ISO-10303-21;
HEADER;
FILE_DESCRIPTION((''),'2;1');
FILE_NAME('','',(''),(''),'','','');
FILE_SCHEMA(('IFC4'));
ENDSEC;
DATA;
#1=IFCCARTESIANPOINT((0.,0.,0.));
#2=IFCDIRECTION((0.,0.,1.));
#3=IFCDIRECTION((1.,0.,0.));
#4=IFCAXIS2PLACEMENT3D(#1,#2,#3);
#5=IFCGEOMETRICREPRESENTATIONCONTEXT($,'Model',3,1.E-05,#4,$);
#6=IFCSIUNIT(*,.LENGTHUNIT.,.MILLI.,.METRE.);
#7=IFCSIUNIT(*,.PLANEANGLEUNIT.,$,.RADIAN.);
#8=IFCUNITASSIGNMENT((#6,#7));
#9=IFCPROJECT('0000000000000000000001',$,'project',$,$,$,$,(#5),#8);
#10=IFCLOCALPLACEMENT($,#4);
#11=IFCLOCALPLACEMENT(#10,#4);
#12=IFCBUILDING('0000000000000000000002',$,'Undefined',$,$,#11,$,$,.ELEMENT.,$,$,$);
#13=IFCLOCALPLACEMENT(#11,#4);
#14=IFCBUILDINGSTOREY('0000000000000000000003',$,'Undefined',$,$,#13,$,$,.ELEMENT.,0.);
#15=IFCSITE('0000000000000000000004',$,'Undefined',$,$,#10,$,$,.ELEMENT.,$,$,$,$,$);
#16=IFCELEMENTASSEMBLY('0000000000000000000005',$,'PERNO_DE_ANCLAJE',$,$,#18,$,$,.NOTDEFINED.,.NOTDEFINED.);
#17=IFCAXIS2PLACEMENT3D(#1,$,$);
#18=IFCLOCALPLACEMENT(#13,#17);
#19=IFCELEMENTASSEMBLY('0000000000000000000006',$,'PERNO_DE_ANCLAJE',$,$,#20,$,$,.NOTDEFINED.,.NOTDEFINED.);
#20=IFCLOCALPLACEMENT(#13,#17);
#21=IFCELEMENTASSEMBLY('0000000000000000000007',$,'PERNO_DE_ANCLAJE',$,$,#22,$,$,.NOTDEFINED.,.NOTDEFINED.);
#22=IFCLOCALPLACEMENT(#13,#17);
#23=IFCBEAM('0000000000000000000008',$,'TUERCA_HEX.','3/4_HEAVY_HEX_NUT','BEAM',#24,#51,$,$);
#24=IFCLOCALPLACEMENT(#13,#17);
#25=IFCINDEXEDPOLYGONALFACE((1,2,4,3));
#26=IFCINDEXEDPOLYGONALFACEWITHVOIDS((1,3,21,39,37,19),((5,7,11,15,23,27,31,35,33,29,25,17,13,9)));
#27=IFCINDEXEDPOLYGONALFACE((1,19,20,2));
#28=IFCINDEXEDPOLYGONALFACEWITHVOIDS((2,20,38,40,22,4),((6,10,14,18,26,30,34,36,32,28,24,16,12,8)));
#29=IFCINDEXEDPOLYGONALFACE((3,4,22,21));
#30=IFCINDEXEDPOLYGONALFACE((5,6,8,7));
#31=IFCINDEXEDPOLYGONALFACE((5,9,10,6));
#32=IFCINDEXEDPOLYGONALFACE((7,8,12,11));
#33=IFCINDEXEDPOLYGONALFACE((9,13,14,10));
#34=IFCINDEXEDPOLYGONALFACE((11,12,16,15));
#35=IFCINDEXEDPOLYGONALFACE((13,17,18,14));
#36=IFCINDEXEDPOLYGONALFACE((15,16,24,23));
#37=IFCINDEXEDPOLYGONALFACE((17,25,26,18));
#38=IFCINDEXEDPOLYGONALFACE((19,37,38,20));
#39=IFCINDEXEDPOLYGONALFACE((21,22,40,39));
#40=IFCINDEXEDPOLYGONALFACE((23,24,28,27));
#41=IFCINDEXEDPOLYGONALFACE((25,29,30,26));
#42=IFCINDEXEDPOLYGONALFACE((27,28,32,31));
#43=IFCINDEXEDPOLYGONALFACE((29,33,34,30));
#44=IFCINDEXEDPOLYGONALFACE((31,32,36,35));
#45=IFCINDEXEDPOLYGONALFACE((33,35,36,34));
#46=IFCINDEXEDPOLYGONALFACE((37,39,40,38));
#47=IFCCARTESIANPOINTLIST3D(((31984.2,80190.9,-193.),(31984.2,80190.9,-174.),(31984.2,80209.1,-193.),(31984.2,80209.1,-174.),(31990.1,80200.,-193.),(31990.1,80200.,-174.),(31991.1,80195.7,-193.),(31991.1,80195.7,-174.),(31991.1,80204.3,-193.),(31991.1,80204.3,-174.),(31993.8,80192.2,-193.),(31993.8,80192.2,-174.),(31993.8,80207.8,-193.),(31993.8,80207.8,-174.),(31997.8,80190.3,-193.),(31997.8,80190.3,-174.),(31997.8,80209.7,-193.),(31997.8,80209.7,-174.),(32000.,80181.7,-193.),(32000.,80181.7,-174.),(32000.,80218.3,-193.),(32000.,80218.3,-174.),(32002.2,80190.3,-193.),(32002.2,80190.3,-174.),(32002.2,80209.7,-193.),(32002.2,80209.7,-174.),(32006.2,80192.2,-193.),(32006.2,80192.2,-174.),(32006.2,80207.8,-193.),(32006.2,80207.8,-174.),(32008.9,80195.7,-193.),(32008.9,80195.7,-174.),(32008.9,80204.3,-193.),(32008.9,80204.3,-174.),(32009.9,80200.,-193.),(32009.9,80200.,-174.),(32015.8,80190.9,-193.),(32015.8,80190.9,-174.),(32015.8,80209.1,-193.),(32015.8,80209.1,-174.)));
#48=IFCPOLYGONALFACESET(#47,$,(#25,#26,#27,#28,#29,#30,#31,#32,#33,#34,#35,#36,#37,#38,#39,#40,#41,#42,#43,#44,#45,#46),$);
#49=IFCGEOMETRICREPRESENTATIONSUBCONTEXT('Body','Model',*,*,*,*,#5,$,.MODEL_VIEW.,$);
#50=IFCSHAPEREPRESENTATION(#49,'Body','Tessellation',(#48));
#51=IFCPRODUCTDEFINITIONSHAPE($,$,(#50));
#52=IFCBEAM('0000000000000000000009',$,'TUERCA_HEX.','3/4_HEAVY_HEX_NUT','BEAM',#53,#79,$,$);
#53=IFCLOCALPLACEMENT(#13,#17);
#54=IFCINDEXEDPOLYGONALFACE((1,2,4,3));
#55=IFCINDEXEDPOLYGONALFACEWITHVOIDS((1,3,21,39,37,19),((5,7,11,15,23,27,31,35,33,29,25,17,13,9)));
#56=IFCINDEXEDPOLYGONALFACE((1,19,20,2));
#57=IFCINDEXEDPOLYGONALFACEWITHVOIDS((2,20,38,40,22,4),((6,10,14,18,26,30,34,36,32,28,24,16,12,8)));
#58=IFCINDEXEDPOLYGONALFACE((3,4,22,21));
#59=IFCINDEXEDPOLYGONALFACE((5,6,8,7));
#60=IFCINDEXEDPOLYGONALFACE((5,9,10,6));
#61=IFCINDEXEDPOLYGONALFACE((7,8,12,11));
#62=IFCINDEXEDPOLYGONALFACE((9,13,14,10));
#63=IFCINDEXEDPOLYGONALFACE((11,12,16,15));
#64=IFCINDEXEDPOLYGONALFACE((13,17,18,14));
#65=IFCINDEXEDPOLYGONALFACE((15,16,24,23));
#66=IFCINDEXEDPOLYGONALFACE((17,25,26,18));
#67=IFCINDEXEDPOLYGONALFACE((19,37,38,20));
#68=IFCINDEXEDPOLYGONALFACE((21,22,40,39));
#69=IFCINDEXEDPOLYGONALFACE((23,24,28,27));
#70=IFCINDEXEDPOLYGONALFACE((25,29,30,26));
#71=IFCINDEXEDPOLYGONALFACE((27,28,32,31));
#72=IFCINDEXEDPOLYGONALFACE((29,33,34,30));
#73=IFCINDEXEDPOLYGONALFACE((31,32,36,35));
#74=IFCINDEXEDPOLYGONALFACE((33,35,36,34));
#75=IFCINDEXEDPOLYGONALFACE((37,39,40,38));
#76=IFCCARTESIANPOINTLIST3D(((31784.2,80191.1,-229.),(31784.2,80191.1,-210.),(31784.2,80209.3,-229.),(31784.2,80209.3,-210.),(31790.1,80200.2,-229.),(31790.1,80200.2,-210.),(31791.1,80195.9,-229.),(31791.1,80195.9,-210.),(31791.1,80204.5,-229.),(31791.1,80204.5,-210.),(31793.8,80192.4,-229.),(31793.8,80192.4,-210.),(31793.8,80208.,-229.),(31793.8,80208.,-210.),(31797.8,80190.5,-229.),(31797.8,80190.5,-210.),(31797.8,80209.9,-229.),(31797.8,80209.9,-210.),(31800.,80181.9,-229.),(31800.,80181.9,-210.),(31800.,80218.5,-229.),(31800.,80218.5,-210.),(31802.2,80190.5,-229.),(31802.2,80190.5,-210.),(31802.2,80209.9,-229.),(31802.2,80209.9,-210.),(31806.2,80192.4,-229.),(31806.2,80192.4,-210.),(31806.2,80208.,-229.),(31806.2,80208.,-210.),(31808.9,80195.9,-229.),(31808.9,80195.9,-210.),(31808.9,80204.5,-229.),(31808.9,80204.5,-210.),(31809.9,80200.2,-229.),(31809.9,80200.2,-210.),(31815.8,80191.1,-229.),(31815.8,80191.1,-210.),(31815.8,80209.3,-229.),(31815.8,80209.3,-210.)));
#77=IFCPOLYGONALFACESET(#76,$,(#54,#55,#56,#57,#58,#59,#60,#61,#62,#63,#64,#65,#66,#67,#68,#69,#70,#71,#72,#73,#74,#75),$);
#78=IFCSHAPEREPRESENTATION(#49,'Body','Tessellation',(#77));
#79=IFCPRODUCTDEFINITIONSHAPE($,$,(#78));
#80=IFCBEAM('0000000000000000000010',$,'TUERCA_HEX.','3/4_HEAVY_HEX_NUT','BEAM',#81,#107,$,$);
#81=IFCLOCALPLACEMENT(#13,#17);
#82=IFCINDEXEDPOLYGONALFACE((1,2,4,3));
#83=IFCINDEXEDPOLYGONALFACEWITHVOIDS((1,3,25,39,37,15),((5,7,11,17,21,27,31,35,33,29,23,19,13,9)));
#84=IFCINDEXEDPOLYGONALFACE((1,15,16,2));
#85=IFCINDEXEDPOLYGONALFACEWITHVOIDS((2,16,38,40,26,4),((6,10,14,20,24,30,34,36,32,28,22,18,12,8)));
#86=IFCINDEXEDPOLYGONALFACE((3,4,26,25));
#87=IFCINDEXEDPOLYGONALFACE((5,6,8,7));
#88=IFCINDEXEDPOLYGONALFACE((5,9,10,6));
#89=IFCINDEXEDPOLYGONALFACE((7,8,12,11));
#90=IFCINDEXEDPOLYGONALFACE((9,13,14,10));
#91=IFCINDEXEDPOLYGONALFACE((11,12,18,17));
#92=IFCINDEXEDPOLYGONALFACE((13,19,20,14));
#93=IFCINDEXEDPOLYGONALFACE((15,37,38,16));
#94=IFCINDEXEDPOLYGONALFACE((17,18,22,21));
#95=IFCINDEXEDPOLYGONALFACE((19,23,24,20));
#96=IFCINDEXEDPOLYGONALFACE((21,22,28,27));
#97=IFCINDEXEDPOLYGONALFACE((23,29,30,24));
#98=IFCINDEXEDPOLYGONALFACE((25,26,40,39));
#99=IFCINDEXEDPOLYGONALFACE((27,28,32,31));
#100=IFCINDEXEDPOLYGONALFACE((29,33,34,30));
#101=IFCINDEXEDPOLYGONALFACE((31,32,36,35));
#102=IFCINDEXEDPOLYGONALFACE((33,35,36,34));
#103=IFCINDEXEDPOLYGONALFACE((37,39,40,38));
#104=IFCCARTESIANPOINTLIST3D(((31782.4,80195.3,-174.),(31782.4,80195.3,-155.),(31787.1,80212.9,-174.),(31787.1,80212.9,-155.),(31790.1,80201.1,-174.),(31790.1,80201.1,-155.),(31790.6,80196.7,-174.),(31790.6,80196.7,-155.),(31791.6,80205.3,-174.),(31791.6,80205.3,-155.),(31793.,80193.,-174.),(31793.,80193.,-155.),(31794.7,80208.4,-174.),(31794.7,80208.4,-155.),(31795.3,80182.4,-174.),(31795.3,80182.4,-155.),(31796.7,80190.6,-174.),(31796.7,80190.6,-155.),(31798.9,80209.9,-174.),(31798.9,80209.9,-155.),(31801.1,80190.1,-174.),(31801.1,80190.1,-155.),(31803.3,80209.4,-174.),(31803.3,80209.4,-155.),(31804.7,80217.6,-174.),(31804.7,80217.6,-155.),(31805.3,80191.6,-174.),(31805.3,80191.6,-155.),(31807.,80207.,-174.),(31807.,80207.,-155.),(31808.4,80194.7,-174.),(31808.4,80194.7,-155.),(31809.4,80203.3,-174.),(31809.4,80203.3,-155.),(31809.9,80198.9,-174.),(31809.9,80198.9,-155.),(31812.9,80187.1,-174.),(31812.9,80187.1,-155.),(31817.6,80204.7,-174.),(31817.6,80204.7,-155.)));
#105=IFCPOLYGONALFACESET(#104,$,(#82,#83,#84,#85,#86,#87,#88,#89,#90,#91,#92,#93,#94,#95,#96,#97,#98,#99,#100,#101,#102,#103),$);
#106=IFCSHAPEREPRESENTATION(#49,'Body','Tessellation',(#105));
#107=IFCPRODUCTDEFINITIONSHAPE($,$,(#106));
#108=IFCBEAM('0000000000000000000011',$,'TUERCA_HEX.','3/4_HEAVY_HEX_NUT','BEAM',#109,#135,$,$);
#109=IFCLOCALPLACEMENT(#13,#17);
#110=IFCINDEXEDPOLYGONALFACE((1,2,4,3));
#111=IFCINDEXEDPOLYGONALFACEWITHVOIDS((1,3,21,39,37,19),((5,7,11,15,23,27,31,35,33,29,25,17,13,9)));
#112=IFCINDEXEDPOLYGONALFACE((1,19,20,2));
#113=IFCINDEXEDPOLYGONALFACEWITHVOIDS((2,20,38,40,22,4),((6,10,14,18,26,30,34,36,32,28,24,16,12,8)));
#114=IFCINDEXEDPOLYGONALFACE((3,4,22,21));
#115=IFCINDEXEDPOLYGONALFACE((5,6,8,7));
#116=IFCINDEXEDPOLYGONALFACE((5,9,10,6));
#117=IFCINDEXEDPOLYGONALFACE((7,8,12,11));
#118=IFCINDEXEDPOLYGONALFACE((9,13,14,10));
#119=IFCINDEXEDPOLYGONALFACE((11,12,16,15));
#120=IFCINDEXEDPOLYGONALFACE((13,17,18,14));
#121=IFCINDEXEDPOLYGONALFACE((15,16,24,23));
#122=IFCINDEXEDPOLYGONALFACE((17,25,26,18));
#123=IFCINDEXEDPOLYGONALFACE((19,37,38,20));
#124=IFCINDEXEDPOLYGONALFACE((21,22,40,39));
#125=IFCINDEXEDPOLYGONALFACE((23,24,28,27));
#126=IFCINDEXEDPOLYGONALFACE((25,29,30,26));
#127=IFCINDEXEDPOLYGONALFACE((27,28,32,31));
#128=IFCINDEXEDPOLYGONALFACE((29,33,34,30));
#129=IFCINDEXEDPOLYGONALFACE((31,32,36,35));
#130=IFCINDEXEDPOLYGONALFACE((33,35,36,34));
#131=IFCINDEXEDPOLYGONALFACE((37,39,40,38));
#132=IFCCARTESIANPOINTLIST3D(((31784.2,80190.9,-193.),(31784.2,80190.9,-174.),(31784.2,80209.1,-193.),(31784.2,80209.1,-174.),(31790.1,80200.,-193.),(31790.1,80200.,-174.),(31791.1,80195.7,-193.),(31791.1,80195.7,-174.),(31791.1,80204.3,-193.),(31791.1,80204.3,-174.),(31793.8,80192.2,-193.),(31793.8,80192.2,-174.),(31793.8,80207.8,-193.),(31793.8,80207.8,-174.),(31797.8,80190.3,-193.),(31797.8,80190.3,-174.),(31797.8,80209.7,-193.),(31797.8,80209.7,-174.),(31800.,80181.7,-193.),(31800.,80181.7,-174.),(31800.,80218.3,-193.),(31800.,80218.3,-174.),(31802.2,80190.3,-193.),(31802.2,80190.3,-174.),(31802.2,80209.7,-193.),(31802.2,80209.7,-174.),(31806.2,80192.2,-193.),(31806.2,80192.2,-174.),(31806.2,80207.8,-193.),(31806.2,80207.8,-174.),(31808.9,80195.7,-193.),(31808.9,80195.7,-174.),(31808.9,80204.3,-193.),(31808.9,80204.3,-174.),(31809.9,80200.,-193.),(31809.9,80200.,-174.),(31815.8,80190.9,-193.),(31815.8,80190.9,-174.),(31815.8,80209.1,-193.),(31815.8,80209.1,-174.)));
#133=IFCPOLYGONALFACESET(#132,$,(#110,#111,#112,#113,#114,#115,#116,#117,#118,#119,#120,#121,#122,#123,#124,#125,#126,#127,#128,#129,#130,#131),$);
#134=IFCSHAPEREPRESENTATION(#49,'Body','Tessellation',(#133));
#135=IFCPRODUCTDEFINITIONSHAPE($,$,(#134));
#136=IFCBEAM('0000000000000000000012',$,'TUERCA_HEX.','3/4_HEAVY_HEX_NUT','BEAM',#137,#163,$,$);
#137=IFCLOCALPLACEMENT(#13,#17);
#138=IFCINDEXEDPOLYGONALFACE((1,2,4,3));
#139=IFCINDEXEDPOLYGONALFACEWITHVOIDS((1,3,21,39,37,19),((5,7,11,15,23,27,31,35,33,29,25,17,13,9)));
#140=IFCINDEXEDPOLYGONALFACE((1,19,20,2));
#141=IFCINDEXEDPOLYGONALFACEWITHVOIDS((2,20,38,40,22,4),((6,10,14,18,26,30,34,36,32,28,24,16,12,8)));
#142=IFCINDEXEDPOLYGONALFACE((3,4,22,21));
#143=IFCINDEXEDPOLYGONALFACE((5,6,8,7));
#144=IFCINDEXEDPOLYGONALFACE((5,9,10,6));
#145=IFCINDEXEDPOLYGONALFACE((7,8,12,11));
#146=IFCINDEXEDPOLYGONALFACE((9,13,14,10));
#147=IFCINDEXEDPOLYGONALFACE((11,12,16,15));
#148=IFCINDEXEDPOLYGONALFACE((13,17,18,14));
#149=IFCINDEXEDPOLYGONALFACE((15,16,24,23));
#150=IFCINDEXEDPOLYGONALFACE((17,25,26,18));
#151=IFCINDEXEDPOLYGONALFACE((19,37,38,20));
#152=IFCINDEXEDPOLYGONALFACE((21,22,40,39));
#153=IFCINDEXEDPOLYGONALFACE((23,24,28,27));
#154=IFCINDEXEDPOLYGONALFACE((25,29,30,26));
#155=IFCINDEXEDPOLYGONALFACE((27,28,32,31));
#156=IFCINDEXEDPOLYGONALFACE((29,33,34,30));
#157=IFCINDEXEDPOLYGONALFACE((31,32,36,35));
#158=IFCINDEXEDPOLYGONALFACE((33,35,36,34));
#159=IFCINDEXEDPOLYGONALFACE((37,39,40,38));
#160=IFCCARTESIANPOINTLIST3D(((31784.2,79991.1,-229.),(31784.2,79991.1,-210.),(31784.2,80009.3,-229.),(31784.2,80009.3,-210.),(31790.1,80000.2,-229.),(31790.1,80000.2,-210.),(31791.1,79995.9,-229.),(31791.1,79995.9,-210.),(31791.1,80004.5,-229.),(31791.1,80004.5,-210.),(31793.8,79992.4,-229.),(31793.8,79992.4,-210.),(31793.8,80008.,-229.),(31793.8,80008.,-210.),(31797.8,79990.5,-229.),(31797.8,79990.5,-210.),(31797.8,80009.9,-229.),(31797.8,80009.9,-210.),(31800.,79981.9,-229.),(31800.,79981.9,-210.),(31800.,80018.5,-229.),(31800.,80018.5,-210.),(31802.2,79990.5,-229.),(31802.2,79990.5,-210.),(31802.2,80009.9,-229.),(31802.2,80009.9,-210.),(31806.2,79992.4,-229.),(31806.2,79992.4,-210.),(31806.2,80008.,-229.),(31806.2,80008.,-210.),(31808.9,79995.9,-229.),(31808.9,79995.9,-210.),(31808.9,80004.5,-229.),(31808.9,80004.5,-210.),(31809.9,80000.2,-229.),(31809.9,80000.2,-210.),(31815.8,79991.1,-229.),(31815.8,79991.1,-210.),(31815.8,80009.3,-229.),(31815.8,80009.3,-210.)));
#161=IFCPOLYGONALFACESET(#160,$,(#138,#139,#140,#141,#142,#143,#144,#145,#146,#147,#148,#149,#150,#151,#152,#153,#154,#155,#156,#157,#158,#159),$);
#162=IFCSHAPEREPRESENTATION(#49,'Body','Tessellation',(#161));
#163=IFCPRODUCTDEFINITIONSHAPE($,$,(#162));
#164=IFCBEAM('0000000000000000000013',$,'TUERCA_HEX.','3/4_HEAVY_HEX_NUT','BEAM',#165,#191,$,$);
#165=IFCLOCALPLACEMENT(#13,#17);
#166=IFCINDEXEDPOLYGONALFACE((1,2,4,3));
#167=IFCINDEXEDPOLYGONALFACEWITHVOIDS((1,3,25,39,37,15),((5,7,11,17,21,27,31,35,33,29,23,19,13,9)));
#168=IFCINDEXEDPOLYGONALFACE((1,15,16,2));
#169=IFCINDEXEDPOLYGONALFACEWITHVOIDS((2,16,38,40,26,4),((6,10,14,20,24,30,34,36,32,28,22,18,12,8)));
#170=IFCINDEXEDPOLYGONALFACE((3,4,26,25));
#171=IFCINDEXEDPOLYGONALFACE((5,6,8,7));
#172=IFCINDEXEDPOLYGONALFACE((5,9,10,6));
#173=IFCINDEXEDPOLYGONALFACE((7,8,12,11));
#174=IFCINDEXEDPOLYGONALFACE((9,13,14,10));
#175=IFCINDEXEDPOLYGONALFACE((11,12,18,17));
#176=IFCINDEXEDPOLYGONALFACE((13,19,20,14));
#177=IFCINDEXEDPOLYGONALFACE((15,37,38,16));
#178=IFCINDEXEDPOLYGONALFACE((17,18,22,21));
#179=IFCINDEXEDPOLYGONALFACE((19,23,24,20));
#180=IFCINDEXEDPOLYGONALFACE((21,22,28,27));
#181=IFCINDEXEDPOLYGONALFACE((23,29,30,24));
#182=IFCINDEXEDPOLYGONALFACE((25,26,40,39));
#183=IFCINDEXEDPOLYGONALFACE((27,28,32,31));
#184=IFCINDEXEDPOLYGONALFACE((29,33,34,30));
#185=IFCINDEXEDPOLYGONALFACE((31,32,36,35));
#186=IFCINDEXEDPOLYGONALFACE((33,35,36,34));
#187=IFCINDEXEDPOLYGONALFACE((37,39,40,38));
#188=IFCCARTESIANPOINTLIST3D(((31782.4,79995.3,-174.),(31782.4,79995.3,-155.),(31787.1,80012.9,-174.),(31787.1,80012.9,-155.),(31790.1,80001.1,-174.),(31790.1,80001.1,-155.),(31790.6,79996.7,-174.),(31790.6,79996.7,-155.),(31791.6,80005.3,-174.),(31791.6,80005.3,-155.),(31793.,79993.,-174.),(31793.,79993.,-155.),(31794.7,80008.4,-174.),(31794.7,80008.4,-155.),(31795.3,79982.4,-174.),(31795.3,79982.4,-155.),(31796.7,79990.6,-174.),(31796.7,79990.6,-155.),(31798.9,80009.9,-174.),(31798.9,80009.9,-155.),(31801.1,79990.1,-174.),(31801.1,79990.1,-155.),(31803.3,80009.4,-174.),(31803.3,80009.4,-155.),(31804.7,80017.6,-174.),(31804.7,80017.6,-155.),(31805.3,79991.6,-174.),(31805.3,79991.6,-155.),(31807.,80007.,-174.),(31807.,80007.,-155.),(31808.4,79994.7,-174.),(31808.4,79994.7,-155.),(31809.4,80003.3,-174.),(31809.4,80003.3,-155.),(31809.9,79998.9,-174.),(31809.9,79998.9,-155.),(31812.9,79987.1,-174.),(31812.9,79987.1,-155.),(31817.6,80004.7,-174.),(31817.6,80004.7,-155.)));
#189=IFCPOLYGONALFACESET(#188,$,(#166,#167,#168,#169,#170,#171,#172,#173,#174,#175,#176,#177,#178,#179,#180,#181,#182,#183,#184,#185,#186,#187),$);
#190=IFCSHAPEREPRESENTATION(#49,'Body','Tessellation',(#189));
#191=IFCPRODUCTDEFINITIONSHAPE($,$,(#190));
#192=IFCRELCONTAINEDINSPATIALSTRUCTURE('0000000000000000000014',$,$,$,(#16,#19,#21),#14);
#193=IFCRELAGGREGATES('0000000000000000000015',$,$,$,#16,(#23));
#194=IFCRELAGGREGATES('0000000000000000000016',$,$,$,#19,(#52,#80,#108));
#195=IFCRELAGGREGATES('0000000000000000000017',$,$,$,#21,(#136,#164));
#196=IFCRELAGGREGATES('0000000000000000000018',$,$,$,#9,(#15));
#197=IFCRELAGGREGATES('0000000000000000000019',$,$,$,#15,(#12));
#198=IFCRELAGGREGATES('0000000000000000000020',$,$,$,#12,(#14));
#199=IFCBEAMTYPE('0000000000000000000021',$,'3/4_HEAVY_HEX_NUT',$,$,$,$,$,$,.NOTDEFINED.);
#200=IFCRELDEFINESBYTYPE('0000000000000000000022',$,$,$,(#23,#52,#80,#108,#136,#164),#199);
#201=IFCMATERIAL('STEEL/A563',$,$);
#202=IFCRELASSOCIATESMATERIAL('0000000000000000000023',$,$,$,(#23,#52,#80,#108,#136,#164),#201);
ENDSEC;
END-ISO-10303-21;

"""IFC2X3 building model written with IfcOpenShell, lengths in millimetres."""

from ifc_helpers import new_model, si_unit, frame, origin_with_axes, place, context, subcontext, project, spatial, polyline, outline, extrude, material, type_object, element, aggregate, save


model = new_model("IFC2X3")

# Units and contexts
model_context = context("Model", 3, precision=1e-05, world=origin_with_axes())
body_context = subcontext(model_context, "Body", "Model", "MODEL_VIEW")
ifc_project = project(units=[si_unit("LENGTHUNIT", "METRE", prefix="MILLI"), si_unit("PLANEANGLEUNIT", "RADIAN")], contexts=[model_context])

# Site, building, storey
site_placement = place(None, origin_with_axes())
site = spatial("IfcSite", under=ifc_project, at=site_placement, Name="Undefined", CompositionType="ELEMENT")
building_placement = place(site_placement, origin_with_axes())
building = spatial("IfcBuilding", under=site, at=building_placement, Name="Undefined", CompositionType="ELEMENT")
storey_placement = place(building_placement, origin_with_axes())
storey = spatial("IfcBuildingStorey", under=building, at=storey_placement, Name="Undefined", CompositionType="ELEMENT", Elevation=0.0)

# Element assemblies
assembly_1_placement = place(storey_placement, origin_with_axes())
assembly_1 = element("IfcElementAssembly", 1, at=assembly_1_placement, inside=storey, Name="PERNO_DE_ANCLAJE", AssemblyPlace="NOTDEFINED", PredefinedType="NOTDEFINED")
ifc_material_1 = material(Name="STEEL/A563")
assembly_2_placement = place(storey_placement, origin_with_axes())
assembly_2 = element("IfcElementAssembly", 2, at=assembly_2_placement, inside=storey, Name="PERNO_DE_ANCLAJE", AssemblyPlace="NOTDEFINED", PredefinedType="NOTDEFINED")
assembly_3_placement = place(storey_placement, origin_with_axes())
assembly_3 = element("IfcElementAssembly", 3, at=assembly_3_placement, inside=storey, Name="PERNO_DE_ANCLAJE", AssemblyPlace="NOTDEFINED", PredefinedType="NOTDEFINED")

# Beams
beam_type_1 = type_object("IfcBeamType", Name="3/4_HEAVY_HEX_NUT", PredefinedType="NOTDEFINED")
beam_1_placement = place(assembly_1_placement, frame((32000.0, 80200.0, -174.0), z_axis=(1.0, 0.0, 0.0), x_axis=(0.0, 0.0, -1.0)))
beam_1 = element("IfcBeam", 4, at=beam_1_placement, type_object=beam_type_1, material=ifc_material_1, Name="TUERCA_HEX.", Description="3/4_HEAVY_HEX_NUT", ObjectType="BEAM", context=body_context, shape_type="SweptSolid", body=[
    extrude(outline(polyline([(-9.1, -15.8), (-18.3, 0.0), (-9.1, 15.8), (9.1, 15.8), (18.3, 0.0), (9.1, -15.8), (-9.1, -15.8)]), holes=[polyline([(7.8, 6.2), (4.3, 8.9), (0.0, 9.9), (-4.3, 8.9), (-7.8, 6.2), (-9.7, 2.2), (-9.7, -2.2), (-7.8, -6.2), (-4.3, -8.9), (0.0, -9.9), (4.3, -8.9), (7.8, -6.2), (9.7, -2.2), (9.7, 2.2), (7.8, 6.2)])]), frame((19.0, 0.0, 0.0), z_axis=(-1.0, 0.0, 0.0), x_axis=(0.0, -1.0, 0.0)), (0.0, 0.0, 1.0), 19.0),
])
aggregate(assembly_1, [beam_1])
beam_2_placement = place(assembly_2_placement, frame((31800.0, 80200.2, -210.0), z_axis=(1.0, 0.0, 0.0), x_axis=(0.0, 0.0, -1.0)))
beam_2 = element("IfcBeam", 5, at=beam_2_placement, type_object=beam_type_1, material=ifc_material_1, Name="TUERCA_HEX.", Description="3/4_HEAVY_HEX_NUT", ObjectType="BEAM", context=body_context, shape_type="SweptSolid", body=[
    extrude(outline(polyline([(-9.1, -15.8), (-18.3, 0.0), (-9.1, 15.8), (9.1, 15.8), (18.3, 0.0), (9.1, -15.8), (-9.1, -15.8)]), holes=[polyline([(7.8, 6.2), (4.3, 8.9), (0.0, 9.9), (-4.3, 8.9), (-7.8, 6.2), (-9.7, 2.2), (-9.7, -2.2), (-7.8, -6.2), (-4.3, -8.9), (0.0, -9.9), (4.3, -8.9), (7.8, -6.2), (9.7, -2.2), (9.7, 2.2), (7.8, 6.2)])]), frame((19.0, 0.0, 0.0), z_axis=(-1.0, 0.0, 0.0), x_axis=(0.0, -1.0, 0.0)), (0.0, 0.0, 1.0), 19.0),
])
beam_3_placement = place(assembly_2_placement, frame((31800.0, 80200.0, -155.0), z_axis=(0.707107, 0.707107, 0.0), x_axis=(0.0, 0.0, -1.0)))
beam_3 = element("IfcBeam", 6, at=beam_3_placement, type_object=beam_type_1, material=ifc_material_1, Name="TUERCA_HEX.", Description="3/4_HEAVY_HEX_NUT", ObjectType="BEAM", context=body_context, shape_type="SweptSolid", body=[
    extrude(outline(polyline([(-9.1, -15.8), (-18.3, 0.0), (-9.1, 15.8), (9.1, 15.8), (18.3, 0.0), (9.1, -15.8), (-9.1, -15.8)]), holes=[polyline([(7.8, 6.2), (4.3, 8.9), (0.0, 9.9), (-4.3, 8.9), (-7.8, 6.2), (-9.7, 2.2), (-9.7, -2.2), (-7.8, -6.2), (-4.3, -8.9), (0.0, -9.9), (4.3, -8.9), (7.8, -6.2), (9.7, -2.2), (9.7, 2.2), (7.8, 6.2)])]), frame((19.0, 0.0, 0.0), z_axis=(-1.0, 0.0, 0.0), x_axis=(0.0, -1.0, 0.0)), (0.0, 0.0, 1.0), 19.0),
])
beam_4_placement = place(assembly_2_placement, frame((31800.0, 80200.0, -174.0), z_axis=(1.0, 0.0, 0.0), x_axis=(0.0, 0.0, -1.0)))
beam_4 = element("IfcBeam", 7, at=beam_4_placement, type_object=beam_type_1, material=ifc_material_1, Name="TUERCA_HEX.", Description="3/4_HEAVY_HEX_NUT", ObjectType="BEAM", context=body_context, shape_type="SweptSolid", body=[
    extrude(outline(polyline([(-9.1, -15.8), (-18.3, 0.0), (-9.1, 15.8), (9.1, 15.8), (18.3, 0.0), (9.1, -15.8), (-9.1, -15.8)]), holes=[polyline([(7.8, 6.2), (4.3, 8.9), (0.0, 9.9), (-4.3, 8.9), (-7.8, 6.2), (-9.7, 2.2), (-9.7, -2.2), (-7.8, -6.2), (-4.3, -8.9), (0.0, -9.9), (4.3, -8.9), (7.8, -6.2), (9.7, -2.2), (9.7, 2.2), (7.8, 6.2)])]), frame((19.0, 0.0, 0.0), z_axis=(-1.0, 0.0, 0.0), x_axis=(0.0, -1.0, 0.0)), (0.0, 0.0, 1.0), 19.0),
])
aggregate(assembly_2, [beam_2, beam_3, beam_4])
beam_5_placement = place(assembly_3_placement, frame((31800.0, 80000.2, -210.0), z_axis=(1.0, 0.0, 0.0), x_axis=(0.0, 0.0, -1.0)))
beam_5 = element("IfcBeam", 8, at=beam_5_placement, type_object=beam_type_1, material=ifc_material_1, Name="TUERCA_HEX.", Description="3/4_HEAVY_HEX_NUT", ObjectType="BEAM", context=body_context, shape_type="SweptSolid", body=[
    extrude(outline(polyline([(-9.1, -15.8), (-18.3, 0.0), (-9.1, 15.8), (9.1, 15.8), (18.3, 0.0), (9.1, -15.8), (-9.1, -15.8)]), holes=[polyline([(7.8, 6.2), (4.3, 8.9), (0.0, 9.9), (-4.3, 8.9), (-7.8, 6.2), (-9.7, 2.2), (-9.7, -2.2), (-7.8, -6.2), (-4.3, -8.9), (0.0, -9.9), (4.3, -8.9), (7.8, -6.2), (9.7, -2.2), (9.7, 2.2), (7.8, 6.2)])]), frame((19.0, 0.0, 0.0), z_axis=(-1.0, 0.0, 0.0), x_axis=(0.0, -1.0, 0.0)), (0.0, 0.0, 1.0), 19.0),
])
beam_6_placement = place(assembly_3_placement, frame((31800.0, 80000.0, -155.0), z_axis=(0.707107, 0.707107, 0.0), x_axis=(0.0, 0.0, -1.0)))
beam_6 = element("IfcBeam", 9, at=beam_6_placement, type_object=beam_type_1, material=ifc_material_1, Name="TUERCA_HEX.", Description="3/4_HEAVY_HEX_NUT", ObjectType="BEAM", context=body_context, shape_type="SweptSolid", body=[
    extrude(outline(polyline([(-9.1, -15.8), (-18.3, 0.0), (-9.1, 15.8), (9.1, 15.8), (18.3, 0.0), (9.1, -15.8), (-9.1, -15.8)]), holes=[polyline([(7.8, 6.2), (4.3, 8.9), (0.0, 9.9), (-4.3, 8.9), (-7.8, 6.2), (-9.7, 2.2), (-9.7, -2.2), (-7.8, -6.2), (-4.3, -8.9), (0.0, -9.9), (4.3, -8.9), (7.8, -6.2), (9.7, -2.2), (9.7, 2.2), (7.8, 6.2)])]), frame((19.0, 0.0, 0.0), z_axis=(-1.0, 0.0, 0.0), x_axis=(0.0, -1.0, 0.0)), (0.0, 0.0, 1.0), 19.0),
])
aggregate(assembly_3, [beam_5, beam_6])

save(model, "model.ifc")
